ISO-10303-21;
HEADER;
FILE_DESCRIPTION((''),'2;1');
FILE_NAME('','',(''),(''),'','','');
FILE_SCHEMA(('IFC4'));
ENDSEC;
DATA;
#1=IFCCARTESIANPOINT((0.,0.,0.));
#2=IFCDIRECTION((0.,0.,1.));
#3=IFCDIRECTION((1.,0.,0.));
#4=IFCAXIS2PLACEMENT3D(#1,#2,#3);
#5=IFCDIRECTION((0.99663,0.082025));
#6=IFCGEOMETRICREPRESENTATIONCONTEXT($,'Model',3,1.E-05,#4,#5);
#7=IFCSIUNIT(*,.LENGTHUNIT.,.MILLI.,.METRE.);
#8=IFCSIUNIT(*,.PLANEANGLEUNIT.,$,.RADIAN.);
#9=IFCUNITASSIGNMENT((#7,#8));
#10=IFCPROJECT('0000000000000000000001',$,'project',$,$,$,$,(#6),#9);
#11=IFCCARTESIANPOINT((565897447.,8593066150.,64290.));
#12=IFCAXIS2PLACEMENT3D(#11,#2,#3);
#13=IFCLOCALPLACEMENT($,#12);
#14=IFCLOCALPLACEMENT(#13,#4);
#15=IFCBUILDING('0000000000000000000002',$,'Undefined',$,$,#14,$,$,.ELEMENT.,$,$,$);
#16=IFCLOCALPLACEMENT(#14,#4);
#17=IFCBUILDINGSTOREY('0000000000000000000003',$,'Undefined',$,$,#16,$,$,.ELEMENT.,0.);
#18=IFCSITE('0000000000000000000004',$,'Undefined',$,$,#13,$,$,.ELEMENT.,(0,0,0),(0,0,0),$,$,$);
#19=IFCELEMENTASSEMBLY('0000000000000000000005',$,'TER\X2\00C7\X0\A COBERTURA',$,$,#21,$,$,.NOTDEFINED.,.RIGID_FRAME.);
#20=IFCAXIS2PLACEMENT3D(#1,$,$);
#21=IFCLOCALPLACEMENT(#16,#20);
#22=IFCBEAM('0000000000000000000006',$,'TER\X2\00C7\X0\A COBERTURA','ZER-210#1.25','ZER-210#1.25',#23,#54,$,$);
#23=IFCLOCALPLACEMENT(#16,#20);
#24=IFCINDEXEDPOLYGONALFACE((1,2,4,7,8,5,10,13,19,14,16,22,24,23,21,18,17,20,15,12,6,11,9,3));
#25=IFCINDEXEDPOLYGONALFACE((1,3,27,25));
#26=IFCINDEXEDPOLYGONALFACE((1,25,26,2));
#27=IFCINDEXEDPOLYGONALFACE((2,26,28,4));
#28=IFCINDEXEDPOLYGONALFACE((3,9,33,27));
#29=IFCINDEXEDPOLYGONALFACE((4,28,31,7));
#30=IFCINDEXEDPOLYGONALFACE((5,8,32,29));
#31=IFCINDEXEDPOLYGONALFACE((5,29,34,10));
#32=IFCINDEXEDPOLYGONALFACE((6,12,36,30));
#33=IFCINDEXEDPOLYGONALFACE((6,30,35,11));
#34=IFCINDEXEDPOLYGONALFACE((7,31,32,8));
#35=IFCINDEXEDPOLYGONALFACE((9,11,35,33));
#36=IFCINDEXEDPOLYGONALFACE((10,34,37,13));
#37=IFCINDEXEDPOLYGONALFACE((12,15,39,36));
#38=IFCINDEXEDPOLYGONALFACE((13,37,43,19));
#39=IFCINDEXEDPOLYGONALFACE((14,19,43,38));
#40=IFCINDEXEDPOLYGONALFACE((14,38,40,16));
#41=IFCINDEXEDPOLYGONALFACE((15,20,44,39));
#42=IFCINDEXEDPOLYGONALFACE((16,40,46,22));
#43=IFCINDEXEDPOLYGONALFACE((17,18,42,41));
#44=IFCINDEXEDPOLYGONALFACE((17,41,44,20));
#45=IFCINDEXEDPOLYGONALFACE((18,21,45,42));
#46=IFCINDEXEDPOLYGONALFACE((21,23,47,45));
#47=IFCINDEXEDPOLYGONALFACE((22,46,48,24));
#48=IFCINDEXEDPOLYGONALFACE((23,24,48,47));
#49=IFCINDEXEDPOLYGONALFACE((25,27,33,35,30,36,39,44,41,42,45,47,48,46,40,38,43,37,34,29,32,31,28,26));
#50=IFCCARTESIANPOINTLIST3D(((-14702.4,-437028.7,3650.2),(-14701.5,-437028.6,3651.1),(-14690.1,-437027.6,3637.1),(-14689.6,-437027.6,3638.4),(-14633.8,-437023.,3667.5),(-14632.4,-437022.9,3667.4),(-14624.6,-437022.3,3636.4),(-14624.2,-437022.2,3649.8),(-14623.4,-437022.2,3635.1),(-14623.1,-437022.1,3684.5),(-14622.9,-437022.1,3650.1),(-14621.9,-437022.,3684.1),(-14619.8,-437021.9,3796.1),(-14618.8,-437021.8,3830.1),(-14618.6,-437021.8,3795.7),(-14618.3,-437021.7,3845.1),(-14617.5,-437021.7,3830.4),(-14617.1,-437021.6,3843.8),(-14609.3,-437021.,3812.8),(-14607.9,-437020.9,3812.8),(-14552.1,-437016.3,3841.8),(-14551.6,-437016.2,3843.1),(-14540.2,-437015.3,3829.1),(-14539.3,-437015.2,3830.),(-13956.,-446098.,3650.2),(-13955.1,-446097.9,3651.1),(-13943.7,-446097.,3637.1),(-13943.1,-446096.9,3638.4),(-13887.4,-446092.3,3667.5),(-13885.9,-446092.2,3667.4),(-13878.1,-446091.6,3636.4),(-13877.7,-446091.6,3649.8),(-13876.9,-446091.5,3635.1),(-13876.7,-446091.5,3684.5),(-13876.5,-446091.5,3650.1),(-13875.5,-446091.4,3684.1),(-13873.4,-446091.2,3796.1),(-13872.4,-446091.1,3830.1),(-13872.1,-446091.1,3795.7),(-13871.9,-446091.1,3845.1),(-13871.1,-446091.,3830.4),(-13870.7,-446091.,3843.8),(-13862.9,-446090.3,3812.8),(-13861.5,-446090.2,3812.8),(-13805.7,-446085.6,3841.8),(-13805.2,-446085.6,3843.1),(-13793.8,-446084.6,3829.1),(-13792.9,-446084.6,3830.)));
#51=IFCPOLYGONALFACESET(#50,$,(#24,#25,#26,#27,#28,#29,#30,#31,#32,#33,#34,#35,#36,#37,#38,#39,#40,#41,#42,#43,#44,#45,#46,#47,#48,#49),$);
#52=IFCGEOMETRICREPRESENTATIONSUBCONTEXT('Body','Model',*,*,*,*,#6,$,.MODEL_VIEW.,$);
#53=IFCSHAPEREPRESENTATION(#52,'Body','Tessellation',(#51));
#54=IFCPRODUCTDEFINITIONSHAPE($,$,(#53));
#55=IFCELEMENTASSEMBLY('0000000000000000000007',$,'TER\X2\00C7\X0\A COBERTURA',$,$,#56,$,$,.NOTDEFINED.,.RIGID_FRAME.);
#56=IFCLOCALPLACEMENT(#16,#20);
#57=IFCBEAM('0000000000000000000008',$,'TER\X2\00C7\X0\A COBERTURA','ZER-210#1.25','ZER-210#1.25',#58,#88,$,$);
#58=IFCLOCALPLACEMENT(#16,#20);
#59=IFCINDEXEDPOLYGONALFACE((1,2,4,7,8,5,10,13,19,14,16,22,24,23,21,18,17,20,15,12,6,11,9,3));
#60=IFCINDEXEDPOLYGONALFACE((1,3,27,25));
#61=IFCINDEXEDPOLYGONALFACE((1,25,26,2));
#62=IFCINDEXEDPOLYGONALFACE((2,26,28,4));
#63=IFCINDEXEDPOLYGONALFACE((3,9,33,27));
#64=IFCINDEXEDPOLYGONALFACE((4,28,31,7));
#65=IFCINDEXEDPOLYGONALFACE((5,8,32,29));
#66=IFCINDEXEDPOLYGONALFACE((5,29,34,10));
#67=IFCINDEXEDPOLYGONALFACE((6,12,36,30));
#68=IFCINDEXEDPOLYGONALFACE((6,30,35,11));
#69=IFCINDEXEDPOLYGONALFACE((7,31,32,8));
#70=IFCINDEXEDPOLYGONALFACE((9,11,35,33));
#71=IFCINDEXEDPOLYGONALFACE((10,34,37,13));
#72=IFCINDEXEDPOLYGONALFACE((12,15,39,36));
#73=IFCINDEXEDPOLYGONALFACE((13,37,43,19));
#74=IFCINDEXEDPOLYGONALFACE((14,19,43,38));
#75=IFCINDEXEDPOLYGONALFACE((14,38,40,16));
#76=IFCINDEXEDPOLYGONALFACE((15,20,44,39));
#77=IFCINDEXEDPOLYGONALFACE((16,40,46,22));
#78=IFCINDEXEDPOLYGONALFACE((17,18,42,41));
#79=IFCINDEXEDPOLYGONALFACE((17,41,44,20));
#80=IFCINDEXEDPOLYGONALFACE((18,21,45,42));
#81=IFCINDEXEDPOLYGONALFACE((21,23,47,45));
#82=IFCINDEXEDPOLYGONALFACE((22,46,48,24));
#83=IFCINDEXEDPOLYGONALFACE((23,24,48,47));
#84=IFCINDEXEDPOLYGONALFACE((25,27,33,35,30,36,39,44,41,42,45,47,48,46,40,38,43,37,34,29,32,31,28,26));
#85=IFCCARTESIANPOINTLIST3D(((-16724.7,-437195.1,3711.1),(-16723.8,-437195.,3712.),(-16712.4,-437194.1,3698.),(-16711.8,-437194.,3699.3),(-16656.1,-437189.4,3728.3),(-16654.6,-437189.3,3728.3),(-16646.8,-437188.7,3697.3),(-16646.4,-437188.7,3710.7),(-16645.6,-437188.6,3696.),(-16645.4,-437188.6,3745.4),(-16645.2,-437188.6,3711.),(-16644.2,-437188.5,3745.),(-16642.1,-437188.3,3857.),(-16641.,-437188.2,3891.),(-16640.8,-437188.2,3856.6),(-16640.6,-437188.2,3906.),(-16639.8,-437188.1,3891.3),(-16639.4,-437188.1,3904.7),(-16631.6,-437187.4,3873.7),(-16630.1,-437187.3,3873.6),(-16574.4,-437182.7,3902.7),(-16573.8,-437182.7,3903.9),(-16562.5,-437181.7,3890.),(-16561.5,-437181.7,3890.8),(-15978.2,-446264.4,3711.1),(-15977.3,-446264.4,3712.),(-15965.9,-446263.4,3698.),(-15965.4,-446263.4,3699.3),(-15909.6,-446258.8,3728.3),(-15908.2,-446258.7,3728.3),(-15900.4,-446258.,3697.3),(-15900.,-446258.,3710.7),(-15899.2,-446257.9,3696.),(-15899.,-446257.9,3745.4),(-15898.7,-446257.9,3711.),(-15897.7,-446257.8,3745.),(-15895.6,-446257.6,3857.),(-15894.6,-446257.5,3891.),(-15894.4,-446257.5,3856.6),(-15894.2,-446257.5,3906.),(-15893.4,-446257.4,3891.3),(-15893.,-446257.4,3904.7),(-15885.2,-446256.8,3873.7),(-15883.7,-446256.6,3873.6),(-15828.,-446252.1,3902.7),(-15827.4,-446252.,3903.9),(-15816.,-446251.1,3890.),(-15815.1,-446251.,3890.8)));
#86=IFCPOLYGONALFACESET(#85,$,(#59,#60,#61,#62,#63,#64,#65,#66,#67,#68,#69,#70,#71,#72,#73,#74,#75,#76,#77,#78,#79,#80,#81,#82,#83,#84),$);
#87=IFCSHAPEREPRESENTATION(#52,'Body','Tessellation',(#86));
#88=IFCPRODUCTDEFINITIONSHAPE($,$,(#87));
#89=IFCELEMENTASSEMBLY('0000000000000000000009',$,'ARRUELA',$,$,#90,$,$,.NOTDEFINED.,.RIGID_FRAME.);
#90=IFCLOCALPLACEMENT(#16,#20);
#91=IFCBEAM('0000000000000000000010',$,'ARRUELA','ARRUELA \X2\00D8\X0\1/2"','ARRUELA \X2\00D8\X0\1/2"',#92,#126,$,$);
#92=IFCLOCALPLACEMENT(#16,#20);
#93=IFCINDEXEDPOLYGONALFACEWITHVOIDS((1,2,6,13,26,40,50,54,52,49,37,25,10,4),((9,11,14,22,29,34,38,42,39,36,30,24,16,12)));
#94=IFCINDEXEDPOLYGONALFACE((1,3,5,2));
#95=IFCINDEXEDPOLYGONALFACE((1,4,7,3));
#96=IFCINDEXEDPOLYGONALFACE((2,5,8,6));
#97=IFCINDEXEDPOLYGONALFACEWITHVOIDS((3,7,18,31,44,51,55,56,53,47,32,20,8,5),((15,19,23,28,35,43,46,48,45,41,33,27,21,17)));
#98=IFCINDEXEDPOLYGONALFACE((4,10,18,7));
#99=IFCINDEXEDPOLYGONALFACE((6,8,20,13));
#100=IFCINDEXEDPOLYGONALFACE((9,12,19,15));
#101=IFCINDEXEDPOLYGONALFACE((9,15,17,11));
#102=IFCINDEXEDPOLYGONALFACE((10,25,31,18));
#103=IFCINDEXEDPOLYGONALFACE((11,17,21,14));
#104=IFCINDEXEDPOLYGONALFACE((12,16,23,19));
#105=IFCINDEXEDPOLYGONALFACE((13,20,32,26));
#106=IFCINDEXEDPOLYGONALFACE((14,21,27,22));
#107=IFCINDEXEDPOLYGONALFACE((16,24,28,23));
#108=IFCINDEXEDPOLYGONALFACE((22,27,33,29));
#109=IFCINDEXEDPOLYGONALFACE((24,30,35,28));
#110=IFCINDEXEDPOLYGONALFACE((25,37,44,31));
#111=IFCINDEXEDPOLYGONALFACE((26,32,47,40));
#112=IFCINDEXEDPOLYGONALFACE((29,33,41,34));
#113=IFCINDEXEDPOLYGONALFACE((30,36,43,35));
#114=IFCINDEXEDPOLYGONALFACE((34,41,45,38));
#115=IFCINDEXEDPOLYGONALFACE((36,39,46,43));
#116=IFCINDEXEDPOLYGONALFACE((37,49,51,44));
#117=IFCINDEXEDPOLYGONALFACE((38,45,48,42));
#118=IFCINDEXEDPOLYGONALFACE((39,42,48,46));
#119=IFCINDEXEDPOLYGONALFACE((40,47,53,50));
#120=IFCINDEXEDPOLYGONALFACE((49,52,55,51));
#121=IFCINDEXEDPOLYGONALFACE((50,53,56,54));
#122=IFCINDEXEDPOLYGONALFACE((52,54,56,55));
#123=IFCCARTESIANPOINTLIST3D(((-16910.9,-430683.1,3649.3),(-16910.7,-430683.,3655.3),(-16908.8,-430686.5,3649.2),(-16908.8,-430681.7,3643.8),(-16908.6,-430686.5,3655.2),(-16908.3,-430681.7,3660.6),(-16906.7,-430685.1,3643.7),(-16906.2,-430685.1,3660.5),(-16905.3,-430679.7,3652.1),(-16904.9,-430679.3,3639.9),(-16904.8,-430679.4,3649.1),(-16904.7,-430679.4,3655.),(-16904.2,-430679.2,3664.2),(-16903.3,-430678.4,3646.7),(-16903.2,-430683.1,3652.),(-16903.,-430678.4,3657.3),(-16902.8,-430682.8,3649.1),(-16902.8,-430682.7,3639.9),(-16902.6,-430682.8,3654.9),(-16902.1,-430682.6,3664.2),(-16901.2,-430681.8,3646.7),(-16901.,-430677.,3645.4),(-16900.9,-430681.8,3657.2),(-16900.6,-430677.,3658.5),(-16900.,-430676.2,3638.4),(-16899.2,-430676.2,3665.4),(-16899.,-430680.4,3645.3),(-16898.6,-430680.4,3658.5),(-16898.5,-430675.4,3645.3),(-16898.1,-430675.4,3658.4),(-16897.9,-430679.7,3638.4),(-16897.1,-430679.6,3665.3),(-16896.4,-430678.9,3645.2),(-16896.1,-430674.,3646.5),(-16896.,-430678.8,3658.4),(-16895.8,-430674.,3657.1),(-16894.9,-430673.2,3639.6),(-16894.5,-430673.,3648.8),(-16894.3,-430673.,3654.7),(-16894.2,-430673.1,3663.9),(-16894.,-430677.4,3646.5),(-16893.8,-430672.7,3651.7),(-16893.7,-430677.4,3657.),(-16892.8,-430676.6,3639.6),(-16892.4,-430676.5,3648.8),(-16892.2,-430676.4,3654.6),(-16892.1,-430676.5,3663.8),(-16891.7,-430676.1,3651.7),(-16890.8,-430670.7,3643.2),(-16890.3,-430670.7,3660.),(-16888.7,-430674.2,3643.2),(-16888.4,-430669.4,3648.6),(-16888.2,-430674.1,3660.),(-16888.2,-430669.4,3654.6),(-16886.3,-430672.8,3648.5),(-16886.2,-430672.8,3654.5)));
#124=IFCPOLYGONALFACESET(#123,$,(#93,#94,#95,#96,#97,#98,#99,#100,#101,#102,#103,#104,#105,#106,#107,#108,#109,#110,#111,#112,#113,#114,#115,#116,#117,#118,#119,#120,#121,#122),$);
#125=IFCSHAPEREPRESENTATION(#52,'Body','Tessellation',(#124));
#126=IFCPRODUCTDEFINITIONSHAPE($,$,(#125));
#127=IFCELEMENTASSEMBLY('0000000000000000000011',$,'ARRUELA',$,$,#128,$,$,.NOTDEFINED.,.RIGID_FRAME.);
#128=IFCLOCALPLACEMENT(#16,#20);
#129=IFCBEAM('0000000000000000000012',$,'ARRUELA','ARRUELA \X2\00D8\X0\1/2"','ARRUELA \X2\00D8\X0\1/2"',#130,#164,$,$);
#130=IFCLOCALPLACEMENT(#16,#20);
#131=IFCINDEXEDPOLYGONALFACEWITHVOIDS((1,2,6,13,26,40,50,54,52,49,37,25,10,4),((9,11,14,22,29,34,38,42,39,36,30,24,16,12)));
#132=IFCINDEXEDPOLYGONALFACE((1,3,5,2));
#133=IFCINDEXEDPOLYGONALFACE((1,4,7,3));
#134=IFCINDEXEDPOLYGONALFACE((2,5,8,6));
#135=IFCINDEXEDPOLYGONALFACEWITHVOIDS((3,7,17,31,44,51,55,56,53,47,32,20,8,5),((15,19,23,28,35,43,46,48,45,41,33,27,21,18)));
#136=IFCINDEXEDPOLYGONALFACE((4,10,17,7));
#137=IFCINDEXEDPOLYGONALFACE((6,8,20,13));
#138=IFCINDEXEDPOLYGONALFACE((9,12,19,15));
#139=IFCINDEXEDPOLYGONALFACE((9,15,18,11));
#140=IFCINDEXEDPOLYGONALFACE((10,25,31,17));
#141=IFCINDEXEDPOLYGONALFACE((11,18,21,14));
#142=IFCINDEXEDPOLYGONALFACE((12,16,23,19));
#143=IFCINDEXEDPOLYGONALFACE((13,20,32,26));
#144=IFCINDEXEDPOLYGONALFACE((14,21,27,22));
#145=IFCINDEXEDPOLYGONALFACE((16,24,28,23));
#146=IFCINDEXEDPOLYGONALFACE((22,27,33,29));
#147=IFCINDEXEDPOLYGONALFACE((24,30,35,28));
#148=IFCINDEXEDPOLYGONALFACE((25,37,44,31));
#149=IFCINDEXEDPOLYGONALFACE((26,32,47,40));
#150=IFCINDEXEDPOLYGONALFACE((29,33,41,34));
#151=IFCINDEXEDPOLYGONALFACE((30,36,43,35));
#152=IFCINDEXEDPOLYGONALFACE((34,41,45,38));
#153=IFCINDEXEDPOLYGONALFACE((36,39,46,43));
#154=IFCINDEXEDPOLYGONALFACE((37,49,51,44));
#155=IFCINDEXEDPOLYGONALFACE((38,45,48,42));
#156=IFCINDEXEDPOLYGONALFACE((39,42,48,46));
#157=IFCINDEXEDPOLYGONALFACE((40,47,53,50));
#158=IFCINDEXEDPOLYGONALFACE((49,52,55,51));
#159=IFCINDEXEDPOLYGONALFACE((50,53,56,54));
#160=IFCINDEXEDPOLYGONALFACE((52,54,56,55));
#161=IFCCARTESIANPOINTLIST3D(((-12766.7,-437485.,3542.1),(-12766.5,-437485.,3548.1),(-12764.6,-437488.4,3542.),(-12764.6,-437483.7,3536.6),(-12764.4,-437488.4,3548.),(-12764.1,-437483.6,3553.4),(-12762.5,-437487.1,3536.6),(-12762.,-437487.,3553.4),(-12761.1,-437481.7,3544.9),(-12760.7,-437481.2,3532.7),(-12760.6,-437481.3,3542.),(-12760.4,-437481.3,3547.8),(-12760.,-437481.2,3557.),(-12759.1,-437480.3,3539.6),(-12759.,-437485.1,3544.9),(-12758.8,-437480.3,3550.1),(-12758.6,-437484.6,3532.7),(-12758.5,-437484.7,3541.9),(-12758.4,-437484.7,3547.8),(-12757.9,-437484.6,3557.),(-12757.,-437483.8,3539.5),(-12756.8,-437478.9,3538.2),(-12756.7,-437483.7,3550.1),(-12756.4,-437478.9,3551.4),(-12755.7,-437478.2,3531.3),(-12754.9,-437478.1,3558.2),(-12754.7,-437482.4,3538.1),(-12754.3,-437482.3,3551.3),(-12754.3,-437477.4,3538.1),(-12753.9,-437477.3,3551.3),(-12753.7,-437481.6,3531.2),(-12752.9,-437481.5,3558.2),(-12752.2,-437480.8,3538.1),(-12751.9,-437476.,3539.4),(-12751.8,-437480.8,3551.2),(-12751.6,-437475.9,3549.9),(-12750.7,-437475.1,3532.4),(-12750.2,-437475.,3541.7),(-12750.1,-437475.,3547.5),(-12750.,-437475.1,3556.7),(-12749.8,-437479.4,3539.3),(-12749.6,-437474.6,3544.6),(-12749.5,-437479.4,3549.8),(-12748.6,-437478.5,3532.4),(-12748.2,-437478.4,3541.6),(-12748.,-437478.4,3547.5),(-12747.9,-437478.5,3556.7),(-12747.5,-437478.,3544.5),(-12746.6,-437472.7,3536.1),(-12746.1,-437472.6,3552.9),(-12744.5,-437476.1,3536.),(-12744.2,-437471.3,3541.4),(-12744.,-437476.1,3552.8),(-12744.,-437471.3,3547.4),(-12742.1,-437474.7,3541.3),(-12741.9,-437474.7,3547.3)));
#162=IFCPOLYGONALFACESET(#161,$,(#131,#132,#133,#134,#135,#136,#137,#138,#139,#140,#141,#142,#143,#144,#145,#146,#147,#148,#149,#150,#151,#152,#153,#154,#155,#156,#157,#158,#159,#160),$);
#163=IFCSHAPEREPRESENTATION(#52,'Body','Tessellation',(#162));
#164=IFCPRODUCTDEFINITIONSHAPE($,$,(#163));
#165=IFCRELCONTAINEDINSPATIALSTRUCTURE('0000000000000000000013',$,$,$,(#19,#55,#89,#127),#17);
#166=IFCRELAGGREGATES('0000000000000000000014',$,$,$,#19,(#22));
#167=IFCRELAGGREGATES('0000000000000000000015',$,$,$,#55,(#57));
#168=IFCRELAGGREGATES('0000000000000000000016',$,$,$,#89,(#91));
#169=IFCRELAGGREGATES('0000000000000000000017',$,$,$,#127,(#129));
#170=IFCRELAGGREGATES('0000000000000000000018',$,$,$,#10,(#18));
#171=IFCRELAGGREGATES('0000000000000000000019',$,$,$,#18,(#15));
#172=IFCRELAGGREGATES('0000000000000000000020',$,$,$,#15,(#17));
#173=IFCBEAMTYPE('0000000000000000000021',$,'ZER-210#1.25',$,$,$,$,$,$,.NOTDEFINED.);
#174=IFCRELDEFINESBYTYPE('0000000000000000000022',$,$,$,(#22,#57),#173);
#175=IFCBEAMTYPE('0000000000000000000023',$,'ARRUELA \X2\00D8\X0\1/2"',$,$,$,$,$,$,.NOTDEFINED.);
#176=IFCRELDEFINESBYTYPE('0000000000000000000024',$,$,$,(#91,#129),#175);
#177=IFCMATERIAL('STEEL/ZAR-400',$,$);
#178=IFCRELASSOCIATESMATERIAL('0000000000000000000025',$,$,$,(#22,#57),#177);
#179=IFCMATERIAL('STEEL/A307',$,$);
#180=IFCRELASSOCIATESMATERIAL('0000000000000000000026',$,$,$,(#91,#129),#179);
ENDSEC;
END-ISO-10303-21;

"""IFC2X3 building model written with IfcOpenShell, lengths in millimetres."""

from ifc_helpers import new_model, si_unit, direction, frame, origin_with_axes, place, context, subcontext, project, spatial, polyline, outline, extrude, material, type_object, element, aggregate, save


model = new_model("IFC2X3")

# Units and contexts
model_context = context("Model", 3, precision=1e-05, world=origin_with_axes(), true_north=direction((0.99663, 0.082025)))
body_context = subcontext(model_context, "Body", "Model", "MODEL_VIEW")
ifc_project = project(units=[si_unit("LENGTHUNIT", "METRE", prefix="MILLI"), si_unit("PLANEANGLEUNIT", "RADIAN")], contexts=[model_context])

# Site, building, storey
site_placement = place(None, frame((565897447.0, 8593066150.0, 64290.0), z_axis=(0.0, 0.0, 1.0), x_axis=(1.0, 0.0, 0.0)))
site = spatial("IfcSite", under=ifc_project, at=site_placement, Name="Undefined", CompositionType="ELEMENT", RefLatitude=(0, 0, 0), RefLongitude=(0, 0, 0))
building_placement = place(site_placement, origin_with_axes())
building = spatial("IfcBuilding", under=site, at=building_placement, Name="Undefined", CompositionType="ELEMENT")
storey_placement = place(building_placement, origin_with_axes())
storey = spatial("IfcBuildingStorey", under=building, at=storey_placement, Name="Undefined", CompositionType="ELEMENT", Elevation=0.0)

# Element assemblies, beams
assembly_1_placement = place(storey_placement, origin_with_axes())
assembly_1 = element("IfcElementAssembly", 1, at=assembly_1_placement, inside=storey, Name="TERÇA COBERTURA", AssemblyPlace="NOTDEFINED", PredefinedType="RIGID_FRAME")
ifc_material_1 = material(Name="STEEL/ZAR-400")
beam_type_1 = type_object("IfcBeamType", Name="ZER-210#1.25", PredefinedType="NOTDEFINED")
beam_1_placement = place(assembly_1_placement, frame((-14620.9, -437021.9, 3740.1), z_axis=(0.029885, 0.00246, 0.99955), x_axis=(0.082025, -0.99663, 0.0)))
beam_1 = element("IfcBeam", 2, at=beam_1_placement, type_object=beam_type_1, material=ifc_material_1, Name="TERÇA COBERTURA", Description="ZER-210#1.25", ObjectType="ZER-210#1.25", context=body_context, shape_type="SweptSolid", body=[
    extrude(outline(polyline([(-65.9, 103.7), (-78.2, 91.4), (-79.1, 92.3), (-66.4, 105.0), (0.6, 105.0), (0.6, 90.0), (-9.4, 73.0), (0.6, 56.0), (0.6, -55.7), (10.8, -73.0), (0.6, -90.3), (0.6, -103.8), (65.9, -103.7), (78.2, -91.4), (79.1, -92.3), (66.4, -105.0), (-0.6, -105.0), (-0.6, -90.0), (9.4, -73.0), (-0.6, -56.0), (-0.6, 55.7), (-10.8, 73.0), (-0.6, 90.3), (-0.6, 103.8), (-65.9, 103.7)])), frame((9100.0, 0.0, 0.0), z_axis=(-1.0, 0.0, 0.0), x_axis=(0.0, -1.0, 0.0)), (0.0, 0.0, 1.0), 9100.0),
])
aggregate(assembly_1, [beam_1])
assembly_2_placement = place(storey_placement, origin_with_axes())
assembly_2 = element("IfcElementAssembly", 3, at=assembly_2_placement, inside=storey, Name="TERÇA COBERTURA", AssemblyPlace="NOTDEFINED", PredefinedType="RIGID_FRAME")
beam_2_placement = place(assembly_2_placement, frame((-16643.1, -437188.4, 3801.0), z_axis=(0.029885, 0.00246, 0.99955), x_axis=(0.082025, -0.99663, 0.0)))
beam_2 = element("IfcBeam", 4, at=beam_2_placement, type_object=beam_type_1, material=ifc_material_1, Name="TERÇA COBERTURA", Description="ZER-210#1.25", ObjectType="ZER-210#1.25", context=body_context, shape_type="SweptSolid", body=[
    extrude(outline(polyline([(-65.9, 103.7), (-78.2, 91.4), (-79.1, 92.3), (-66.4, 105.0), (0.6, 105.0), (0.6, 90.0), (-9.4, 73.0), (0.6, 56.0), (0.6, -55.7), (10.8, -73.0), (0.6, -90.3), (0.6, -103.8), (65.9, -103.7), (78.2, -91.4), (79.1, -92.3), (66.4, -105.0), (-0.6, -105.0), (-0.6, -90.0), (9.4, -73.0), (-0.6, -56.0), (-0.6, 55.7), (-10.8, 73.0), (-0.6, 90.3), (-0.6, 103.8), (-65.9, 103.7)])), frame((9100.0, 0.0, 0.0), z_axis=(-1.0, 0.0, 0.0), x_axis=(0.0, -1.0, 0.0)), (0.0, 0.0, 1.0), 9100.0),
])
aggregate(assembly_2, [beam_2])
assembly_3_placement = place(storey_placement, origin_with_axes())
assembly_3 = element("IfcElementAssembly", 5, at=assembly_3_placement, inside=storey, Name="ARRUELA", AssemblyPlace="NOTDEFINED", PredefinedType="RIGID_FRAME")
ifc_material_2 = material(Name="STEEL/A307")
beam_type_2 = type_object("IfcBeamType", Name="ARRUELA Ø1/2\"", PredefinedType="NOTDEFINED")
beam_3_placement = place(assembly_3_placement, frame((-16899.6, -430676.2, 3651.9), z_axis=(-0.853486, -0.520426, 0.026799), x_axis=(0.520257, -0.853904, -0.013454)))
beam_3 = element("IfcBeam", 6, at=beam_3_placement, type_object=beam_type_2, material=ifc_material_2, Name="ARRUELA", Description="ARRUELA Ø1/2\"", ObjectType="ARRUELA Ø1/2\"", context=body_context, shape_type="SweptSolid", body=[
    extrude(outline(polyline([(-12.2, 5.9), (-8.4, 10.5), (-3.0, 13.2), (3.0, 13.2), (8.4, 10.5), (12.2, 5.9), (13.5, 0.0), (12.2, -5.9), (8.4, -10.5), (3.0, -13.2), (-3.0, -13.2), (-8.4, -10.5), (-12.2, -5.9), (-13.5, 0.0), (-12.2, 5.9)]), holes=[polyline([(5.3, 4.2), (2.9, 6.1), (0.0, 6.8), (-2.9, 6.1), (-5.3, 4.2), (-6.6, 1.5), (-6.6, -1.5), (-5.3, -4.2), (-2.9, -6.1), (0.0, -6.7), (2.9, -6.1), (5.3, -4.2), (6.6, -1.5), (6.6, 1.5), (5.3, 4.2)])]), frame((4.0, 0.0, 0.0), z_axis=(-1.0, 0.0, 0.0), x_axis=(0.0, -1.0, 0.0)), (0.0, 0.0, 1.0), 4.0),
])
aggregate(assembly_3, [beam_3])
assembly_4_placement = place(storey_placement, origin_with_axes())
assembly_4 = element("IfcElementAssembly", 7, at=assembly_4_placement, inside=storey, Name="ARRUELA", AssemblyPlace="NOTDEFINED", PredefinedType="RIGID_FRAME")
beam_4_placement = place(assembly_4_placement, frame((-12753.3, -437481.6, 3544.7), z_axis=(-0.853486, -0.520426, 0.026799), x_axis=(-0.520257, 0.853903, 0.013454)))
beam_4 = element("IfcBeam", 8, at=beam_4_placement, type_object=beam_type_2, material=ifc_material_2, Name="ARRUELA", Description="ARRUELA Ø1/2\"", ObjectType="ARRUELA Ø1/2\"", context=body_context, shape_type="SweptSolid", body=[
    extrude(outline(polyline([(-12.2, 5.9), (-8.4, 10.5), (-3.0, 13.2), (3.0, 13.2), (8.4, 10.5), (12.2, 5.9), (13.5, 0.0), (12.2, -5.9), (8.4, -10.5), (3.0, -13.2), (-3.0, -13.2), (-8.4, -10.5), (-12.2, -5.9), (-13.5, 0.0), (-12.2, 5.9)]), holes=[polyline([(5.3, 4.2), (2.9, 6.1), (0.0, 6.8), (-2.9, 6.1), (-5.3, 4.2), (-6.6, 1.5), (-6.6, -1.5), (-5.3, -4.2), (-2.9, -6.1), (0.0, -6.7), (2.9, -6.1), (5.3, -4.2), (6.6, -1.5), (6.6, 1.5), (5.3, 4.2)])]), frame((4.0, 0.0, 0.0), z_axis=(-1.0, 0.0, 0.0), x_axis=(0.0, -1.0, 0.0)), (0.0, 0.0, 1.0), 4.0),
])
aggregate(assembly_4, [beam_4])

save(model, "model.ifc")
